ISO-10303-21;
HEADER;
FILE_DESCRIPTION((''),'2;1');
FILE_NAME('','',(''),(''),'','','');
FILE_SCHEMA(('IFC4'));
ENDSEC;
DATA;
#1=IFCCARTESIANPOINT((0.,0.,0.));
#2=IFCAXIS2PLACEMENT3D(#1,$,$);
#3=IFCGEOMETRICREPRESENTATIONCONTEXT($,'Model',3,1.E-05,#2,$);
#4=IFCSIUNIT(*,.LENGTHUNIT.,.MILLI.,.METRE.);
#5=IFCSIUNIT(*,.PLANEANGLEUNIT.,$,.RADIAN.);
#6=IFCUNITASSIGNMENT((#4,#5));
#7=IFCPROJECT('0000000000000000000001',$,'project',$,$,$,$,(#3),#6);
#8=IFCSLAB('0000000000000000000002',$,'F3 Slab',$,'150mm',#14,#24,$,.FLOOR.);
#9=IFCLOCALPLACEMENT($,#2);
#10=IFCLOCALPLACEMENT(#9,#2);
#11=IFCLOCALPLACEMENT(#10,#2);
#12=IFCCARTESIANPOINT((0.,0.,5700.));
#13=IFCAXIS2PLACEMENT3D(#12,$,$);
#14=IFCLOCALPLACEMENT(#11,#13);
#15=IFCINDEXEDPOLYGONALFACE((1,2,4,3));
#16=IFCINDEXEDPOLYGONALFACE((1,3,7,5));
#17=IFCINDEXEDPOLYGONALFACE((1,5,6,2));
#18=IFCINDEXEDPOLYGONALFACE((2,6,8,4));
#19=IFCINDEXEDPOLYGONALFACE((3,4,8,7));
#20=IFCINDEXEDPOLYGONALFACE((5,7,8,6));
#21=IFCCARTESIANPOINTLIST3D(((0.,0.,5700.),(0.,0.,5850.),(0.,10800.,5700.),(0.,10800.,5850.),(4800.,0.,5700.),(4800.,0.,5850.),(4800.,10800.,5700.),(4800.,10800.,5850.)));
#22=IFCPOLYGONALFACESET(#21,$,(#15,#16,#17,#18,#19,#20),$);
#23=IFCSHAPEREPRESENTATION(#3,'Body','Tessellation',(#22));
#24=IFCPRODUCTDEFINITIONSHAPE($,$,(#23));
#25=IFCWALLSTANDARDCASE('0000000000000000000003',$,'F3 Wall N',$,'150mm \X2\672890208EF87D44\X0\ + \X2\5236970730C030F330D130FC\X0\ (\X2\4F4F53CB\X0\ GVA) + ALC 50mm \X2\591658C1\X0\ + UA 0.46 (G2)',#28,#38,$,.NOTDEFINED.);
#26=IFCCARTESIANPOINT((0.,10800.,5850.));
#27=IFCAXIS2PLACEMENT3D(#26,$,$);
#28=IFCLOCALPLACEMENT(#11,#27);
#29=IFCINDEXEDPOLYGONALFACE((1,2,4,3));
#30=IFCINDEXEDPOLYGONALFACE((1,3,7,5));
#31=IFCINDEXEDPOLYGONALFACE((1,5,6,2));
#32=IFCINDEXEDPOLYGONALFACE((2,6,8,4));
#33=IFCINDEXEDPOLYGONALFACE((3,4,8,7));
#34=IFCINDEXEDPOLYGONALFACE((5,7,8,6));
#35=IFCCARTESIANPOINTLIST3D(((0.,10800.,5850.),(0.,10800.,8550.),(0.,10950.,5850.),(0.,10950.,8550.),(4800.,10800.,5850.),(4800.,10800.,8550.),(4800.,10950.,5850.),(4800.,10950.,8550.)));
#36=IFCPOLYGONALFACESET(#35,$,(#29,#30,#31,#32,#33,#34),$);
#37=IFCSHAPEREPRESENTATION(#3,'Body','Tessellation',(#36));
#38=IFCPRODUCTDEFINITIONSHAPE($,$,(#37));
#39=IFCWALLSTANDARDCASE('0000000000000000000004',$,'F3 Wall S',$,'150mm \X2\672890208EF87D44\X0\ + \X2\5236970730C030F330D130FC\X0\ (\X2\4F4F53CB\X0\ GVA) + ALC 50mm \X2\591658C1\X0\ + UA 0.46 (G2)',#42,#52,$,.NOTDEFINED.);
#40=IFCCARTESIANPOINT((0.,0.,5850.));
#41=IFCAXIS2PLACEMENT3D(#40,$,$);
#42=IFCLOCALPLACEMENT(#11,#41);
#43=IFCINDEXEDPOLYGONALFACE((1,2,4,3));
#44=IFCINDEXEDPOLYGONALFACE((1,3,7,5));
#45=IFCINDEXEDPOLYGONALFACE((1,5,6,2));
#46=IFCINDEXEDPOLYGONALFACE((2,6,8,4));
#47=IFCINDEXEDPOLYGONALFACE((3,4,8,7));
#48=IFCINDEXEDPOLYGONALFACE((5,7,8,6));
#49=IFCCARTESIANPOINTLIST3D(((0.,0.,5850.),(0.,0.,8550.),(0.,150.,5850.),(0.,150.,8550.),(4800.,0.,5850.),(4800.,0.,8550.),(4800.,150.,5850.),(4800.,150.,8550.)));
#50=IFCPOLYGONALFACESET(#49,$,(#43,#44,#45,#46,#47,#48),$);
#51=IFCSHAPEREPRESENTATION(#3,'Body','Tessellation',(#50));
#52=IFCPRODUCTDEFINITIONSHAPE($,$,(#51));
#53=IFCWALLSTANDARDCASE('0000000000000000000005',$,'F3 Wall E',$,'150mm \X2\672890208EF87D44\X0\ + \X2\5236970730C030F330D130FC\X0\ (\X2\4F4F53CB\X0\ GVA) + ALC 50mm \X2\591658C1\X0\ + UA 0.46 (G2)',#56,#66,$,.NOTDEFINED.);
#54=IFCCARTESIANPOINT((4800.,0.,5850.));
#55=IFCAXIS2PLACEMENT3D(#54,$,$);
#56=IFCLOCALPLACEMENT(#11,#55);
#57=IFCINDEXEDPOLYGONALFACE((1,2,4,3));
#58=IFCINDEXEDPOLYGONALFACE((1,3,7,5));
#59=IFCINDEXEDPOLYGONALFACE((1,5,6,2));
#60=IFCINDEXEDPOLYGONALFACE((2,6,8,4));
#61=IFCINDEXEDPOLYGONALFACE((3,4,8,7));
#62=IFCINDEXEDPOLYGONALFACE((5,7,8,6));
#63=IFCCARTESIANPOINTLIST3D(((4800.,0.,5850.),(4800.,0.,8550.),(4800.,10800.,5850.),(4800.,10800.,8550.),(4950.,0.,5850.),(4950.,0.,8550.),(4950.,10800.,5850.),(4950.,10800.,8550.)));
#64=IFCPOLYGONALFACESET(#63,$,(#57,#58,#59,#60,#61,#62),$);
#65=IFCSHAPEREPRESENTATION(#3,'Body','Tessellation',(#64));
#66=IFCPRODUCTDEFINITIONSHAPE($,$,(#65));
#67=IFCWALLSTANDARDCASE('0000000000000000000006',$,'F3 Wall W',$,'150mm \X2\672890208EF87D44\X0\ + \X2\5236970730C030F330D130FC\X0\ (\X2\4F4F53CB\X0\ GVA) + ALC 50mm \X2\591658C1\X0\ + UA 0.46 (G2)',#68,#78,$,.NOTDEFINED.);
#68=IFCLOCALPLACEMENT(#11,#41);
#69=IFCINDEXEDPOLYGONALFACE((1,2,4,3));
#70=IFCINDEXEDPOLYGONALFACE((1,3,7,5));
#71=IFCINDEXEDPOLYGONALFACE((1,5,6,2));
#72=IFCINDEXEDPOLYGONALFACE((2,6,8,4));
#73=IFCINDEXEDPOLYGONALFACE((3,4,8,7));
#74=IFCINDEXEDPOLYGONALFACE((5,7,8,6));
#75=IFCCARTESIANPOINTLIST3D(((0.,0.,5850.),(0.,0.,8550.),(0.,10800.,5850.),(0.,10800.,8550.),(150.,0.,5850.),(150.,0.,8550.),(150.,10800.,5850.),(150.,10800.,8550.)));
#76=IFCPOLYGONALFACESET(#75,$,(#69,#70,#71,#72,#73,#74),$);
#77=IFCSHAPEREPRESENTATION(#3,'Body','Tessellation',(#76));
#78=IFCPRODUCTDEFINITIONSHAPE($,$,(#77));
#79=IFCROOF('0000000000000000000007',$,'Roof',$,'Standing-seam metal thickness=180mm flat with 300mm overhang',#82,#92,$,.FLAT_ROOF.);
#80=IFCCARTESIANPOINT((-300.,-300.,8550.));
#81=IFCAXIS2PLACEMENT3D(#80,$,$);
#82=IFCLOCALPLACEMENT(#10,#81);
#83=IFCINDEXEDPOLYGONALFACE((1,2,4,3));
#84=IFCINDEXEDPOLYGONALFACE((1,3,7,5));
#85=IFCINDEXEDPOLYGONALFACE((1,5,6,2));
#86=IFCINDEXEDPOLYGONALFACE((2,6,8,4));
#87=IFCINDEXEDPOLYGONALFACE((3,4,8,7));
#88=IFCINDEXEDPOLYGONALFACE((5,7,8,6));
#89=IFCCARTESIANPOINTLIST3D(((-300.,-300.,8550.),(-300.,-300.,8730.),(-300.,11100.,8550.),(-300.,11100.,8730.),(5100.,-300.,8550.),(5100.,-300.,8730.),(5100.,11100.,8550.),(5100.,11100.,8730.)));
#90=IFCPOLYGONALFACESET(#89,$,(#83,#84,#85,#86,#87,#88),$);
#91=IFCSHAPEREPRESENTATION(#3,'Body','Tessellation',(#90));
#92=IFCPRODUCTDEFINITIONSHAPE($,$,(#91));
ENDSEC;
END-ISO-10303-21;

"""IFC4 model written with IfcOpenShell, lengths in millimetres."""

from ifc_helpers import new_model, si_unit, frame, frame_2d, origin, place, context, project, rectangle, extrude, element, save


model = new_model("IFC4")

# Units and contexts
model_context = context("Model", 3, precision=1e-05, world=origin())
ifc_project = project(units=[si_unit("LENGTHUNIT", "METRE", prefix="MILLI"), si_unit("PLANEANGLEUNIT", "RADIAN")], contexts=[model_context])

# Slab
placement_1 = place(None, origin())
placement_2 = place(placement_1, origin())
placement_3 = place(placement_2, origin())
slab_placement = place(placement_3, frame((0.0, 0.0, 5700.0)))
element("IfcSlab", 1, at=slab_placement, Name="F3 Slab", ObjectType="150mm", PredefinedType="FLOOR", context=model_context, shape_type="SweptSolid", body=[
    extrude(rectangle(XDim=4800.0, YDim=10800.0, at=frame_2d((2400.0, 5400.0))), frame((0.0, 0.0, 5700.0)), (0.0, 0.0, 1.0), 150.0),
])

# Walls
wall_1_placement = place(placement_3, frame((0.0, 10800.0, 5850.0)))
element("IfcWallStandardCase", 2, at=wall_1_placement, Name="F3 Wall N", ObjectType="150mm 木造軸組 + 制震ダンパー (住友 GVA) + ALC 50mm 外壁 + UA 0.46 (G2)", PredefinedType="NOTDEFINED", context=model_context, shape_type="SweptSolid", body=[
    extrude(rectangle(XDim=4800.0, YDim=150.0, at=frame_2d((2400.0, 75.0))), frame((0.0, 10800.0, 5850.0)), (0.0, 0.0, 1.0), 2700.0),
])
wall_2_placement = place(placement_3, frame((0.0, 0.0, 5850.0)))
element("IfcWallStandardCase", 3, at=wall_2_placement, Name="F3 Wall S", ObjectType="150mm 木造軸組 + 制震ダンパー (住友 GVA) + ALC 50mm 外壁 + UA 0.46 (G2)", PredefinedType="NOTDEFINED", context=model_context, shape_type="SweptSolid", body=[
    extrude(rectangle(XDim=4800.0, YDim=150.0, at=frame_2d((2400.0, 75.0))), frame((0.0, 0.0, 5850.0)), (0.0, 0.0, 1.0), 2700.0),
])
wall_3_placement = place(placement_3, frame((4800.0, 0.0, 5850.0)))
element("IfcWallStandardCase", 4, at=wall_3_placement, Name="F3 Wall E", ObjectType="150mm 木造軸組 + 制震ダンパー (住友 GVA) + ALC 50mm 外壁 + UA 0.46 (G2)", PredefinedType="NOTDEFINED", context=model_context, shape_type="SweptSolid", body=[
    extrude(rectangle(XDim=150.0, YDim=10800.0, at=frame_2d((75.0, 5400.0))), frame((4800.0, 0.0, 5850.0)), (0.0, 0.0, 1.0), 2700.0),
])
wall_4_placement = place(placement_3, frame((0.0, 0.0, 5850.0)))
element("IfcWallStandardCase", 5, at=wall_4_placement, Name="F3 Wall W", ObjectType="150mm 木造軸組 + 制震ダンパー (住友 GVA) + ALC 50mm 外壁 + UA 0.46 (G2)", PredefinedType="NOTDEFINED", context=model_context, shape_type="SweptSolid", body=[
    extrude(rectangle(XDim=150.0, YDim=10800.0, at=frame_2d((75.0, 5400.0))), frame((0.0, 0.0, 5850.0)), (0.0, 0.0, 1.0), 2700.0),
])

# Roof
roof_placement = place(placement_2, frame((-300.0, -300.0, 8550.0)))
element("IfcRoof", 6, at=roof_placement, Name="Roof", ObjectType="Standing-seam metal thickness=180mm flat with 300mm overhang", PredefinedType="FLAT_ROOF", context=model_context, shape_type="SweptSolid", body=[
    extrude(rectangle(XDim=5400.0, YDim=11400.0, at=frame_2d((2700.0, 5700.0))), frame((-300.0, -300.0, 8550.0)), (0.0, 0.0, 1.0), 180.0),
])

save(model, "model.ifc")
